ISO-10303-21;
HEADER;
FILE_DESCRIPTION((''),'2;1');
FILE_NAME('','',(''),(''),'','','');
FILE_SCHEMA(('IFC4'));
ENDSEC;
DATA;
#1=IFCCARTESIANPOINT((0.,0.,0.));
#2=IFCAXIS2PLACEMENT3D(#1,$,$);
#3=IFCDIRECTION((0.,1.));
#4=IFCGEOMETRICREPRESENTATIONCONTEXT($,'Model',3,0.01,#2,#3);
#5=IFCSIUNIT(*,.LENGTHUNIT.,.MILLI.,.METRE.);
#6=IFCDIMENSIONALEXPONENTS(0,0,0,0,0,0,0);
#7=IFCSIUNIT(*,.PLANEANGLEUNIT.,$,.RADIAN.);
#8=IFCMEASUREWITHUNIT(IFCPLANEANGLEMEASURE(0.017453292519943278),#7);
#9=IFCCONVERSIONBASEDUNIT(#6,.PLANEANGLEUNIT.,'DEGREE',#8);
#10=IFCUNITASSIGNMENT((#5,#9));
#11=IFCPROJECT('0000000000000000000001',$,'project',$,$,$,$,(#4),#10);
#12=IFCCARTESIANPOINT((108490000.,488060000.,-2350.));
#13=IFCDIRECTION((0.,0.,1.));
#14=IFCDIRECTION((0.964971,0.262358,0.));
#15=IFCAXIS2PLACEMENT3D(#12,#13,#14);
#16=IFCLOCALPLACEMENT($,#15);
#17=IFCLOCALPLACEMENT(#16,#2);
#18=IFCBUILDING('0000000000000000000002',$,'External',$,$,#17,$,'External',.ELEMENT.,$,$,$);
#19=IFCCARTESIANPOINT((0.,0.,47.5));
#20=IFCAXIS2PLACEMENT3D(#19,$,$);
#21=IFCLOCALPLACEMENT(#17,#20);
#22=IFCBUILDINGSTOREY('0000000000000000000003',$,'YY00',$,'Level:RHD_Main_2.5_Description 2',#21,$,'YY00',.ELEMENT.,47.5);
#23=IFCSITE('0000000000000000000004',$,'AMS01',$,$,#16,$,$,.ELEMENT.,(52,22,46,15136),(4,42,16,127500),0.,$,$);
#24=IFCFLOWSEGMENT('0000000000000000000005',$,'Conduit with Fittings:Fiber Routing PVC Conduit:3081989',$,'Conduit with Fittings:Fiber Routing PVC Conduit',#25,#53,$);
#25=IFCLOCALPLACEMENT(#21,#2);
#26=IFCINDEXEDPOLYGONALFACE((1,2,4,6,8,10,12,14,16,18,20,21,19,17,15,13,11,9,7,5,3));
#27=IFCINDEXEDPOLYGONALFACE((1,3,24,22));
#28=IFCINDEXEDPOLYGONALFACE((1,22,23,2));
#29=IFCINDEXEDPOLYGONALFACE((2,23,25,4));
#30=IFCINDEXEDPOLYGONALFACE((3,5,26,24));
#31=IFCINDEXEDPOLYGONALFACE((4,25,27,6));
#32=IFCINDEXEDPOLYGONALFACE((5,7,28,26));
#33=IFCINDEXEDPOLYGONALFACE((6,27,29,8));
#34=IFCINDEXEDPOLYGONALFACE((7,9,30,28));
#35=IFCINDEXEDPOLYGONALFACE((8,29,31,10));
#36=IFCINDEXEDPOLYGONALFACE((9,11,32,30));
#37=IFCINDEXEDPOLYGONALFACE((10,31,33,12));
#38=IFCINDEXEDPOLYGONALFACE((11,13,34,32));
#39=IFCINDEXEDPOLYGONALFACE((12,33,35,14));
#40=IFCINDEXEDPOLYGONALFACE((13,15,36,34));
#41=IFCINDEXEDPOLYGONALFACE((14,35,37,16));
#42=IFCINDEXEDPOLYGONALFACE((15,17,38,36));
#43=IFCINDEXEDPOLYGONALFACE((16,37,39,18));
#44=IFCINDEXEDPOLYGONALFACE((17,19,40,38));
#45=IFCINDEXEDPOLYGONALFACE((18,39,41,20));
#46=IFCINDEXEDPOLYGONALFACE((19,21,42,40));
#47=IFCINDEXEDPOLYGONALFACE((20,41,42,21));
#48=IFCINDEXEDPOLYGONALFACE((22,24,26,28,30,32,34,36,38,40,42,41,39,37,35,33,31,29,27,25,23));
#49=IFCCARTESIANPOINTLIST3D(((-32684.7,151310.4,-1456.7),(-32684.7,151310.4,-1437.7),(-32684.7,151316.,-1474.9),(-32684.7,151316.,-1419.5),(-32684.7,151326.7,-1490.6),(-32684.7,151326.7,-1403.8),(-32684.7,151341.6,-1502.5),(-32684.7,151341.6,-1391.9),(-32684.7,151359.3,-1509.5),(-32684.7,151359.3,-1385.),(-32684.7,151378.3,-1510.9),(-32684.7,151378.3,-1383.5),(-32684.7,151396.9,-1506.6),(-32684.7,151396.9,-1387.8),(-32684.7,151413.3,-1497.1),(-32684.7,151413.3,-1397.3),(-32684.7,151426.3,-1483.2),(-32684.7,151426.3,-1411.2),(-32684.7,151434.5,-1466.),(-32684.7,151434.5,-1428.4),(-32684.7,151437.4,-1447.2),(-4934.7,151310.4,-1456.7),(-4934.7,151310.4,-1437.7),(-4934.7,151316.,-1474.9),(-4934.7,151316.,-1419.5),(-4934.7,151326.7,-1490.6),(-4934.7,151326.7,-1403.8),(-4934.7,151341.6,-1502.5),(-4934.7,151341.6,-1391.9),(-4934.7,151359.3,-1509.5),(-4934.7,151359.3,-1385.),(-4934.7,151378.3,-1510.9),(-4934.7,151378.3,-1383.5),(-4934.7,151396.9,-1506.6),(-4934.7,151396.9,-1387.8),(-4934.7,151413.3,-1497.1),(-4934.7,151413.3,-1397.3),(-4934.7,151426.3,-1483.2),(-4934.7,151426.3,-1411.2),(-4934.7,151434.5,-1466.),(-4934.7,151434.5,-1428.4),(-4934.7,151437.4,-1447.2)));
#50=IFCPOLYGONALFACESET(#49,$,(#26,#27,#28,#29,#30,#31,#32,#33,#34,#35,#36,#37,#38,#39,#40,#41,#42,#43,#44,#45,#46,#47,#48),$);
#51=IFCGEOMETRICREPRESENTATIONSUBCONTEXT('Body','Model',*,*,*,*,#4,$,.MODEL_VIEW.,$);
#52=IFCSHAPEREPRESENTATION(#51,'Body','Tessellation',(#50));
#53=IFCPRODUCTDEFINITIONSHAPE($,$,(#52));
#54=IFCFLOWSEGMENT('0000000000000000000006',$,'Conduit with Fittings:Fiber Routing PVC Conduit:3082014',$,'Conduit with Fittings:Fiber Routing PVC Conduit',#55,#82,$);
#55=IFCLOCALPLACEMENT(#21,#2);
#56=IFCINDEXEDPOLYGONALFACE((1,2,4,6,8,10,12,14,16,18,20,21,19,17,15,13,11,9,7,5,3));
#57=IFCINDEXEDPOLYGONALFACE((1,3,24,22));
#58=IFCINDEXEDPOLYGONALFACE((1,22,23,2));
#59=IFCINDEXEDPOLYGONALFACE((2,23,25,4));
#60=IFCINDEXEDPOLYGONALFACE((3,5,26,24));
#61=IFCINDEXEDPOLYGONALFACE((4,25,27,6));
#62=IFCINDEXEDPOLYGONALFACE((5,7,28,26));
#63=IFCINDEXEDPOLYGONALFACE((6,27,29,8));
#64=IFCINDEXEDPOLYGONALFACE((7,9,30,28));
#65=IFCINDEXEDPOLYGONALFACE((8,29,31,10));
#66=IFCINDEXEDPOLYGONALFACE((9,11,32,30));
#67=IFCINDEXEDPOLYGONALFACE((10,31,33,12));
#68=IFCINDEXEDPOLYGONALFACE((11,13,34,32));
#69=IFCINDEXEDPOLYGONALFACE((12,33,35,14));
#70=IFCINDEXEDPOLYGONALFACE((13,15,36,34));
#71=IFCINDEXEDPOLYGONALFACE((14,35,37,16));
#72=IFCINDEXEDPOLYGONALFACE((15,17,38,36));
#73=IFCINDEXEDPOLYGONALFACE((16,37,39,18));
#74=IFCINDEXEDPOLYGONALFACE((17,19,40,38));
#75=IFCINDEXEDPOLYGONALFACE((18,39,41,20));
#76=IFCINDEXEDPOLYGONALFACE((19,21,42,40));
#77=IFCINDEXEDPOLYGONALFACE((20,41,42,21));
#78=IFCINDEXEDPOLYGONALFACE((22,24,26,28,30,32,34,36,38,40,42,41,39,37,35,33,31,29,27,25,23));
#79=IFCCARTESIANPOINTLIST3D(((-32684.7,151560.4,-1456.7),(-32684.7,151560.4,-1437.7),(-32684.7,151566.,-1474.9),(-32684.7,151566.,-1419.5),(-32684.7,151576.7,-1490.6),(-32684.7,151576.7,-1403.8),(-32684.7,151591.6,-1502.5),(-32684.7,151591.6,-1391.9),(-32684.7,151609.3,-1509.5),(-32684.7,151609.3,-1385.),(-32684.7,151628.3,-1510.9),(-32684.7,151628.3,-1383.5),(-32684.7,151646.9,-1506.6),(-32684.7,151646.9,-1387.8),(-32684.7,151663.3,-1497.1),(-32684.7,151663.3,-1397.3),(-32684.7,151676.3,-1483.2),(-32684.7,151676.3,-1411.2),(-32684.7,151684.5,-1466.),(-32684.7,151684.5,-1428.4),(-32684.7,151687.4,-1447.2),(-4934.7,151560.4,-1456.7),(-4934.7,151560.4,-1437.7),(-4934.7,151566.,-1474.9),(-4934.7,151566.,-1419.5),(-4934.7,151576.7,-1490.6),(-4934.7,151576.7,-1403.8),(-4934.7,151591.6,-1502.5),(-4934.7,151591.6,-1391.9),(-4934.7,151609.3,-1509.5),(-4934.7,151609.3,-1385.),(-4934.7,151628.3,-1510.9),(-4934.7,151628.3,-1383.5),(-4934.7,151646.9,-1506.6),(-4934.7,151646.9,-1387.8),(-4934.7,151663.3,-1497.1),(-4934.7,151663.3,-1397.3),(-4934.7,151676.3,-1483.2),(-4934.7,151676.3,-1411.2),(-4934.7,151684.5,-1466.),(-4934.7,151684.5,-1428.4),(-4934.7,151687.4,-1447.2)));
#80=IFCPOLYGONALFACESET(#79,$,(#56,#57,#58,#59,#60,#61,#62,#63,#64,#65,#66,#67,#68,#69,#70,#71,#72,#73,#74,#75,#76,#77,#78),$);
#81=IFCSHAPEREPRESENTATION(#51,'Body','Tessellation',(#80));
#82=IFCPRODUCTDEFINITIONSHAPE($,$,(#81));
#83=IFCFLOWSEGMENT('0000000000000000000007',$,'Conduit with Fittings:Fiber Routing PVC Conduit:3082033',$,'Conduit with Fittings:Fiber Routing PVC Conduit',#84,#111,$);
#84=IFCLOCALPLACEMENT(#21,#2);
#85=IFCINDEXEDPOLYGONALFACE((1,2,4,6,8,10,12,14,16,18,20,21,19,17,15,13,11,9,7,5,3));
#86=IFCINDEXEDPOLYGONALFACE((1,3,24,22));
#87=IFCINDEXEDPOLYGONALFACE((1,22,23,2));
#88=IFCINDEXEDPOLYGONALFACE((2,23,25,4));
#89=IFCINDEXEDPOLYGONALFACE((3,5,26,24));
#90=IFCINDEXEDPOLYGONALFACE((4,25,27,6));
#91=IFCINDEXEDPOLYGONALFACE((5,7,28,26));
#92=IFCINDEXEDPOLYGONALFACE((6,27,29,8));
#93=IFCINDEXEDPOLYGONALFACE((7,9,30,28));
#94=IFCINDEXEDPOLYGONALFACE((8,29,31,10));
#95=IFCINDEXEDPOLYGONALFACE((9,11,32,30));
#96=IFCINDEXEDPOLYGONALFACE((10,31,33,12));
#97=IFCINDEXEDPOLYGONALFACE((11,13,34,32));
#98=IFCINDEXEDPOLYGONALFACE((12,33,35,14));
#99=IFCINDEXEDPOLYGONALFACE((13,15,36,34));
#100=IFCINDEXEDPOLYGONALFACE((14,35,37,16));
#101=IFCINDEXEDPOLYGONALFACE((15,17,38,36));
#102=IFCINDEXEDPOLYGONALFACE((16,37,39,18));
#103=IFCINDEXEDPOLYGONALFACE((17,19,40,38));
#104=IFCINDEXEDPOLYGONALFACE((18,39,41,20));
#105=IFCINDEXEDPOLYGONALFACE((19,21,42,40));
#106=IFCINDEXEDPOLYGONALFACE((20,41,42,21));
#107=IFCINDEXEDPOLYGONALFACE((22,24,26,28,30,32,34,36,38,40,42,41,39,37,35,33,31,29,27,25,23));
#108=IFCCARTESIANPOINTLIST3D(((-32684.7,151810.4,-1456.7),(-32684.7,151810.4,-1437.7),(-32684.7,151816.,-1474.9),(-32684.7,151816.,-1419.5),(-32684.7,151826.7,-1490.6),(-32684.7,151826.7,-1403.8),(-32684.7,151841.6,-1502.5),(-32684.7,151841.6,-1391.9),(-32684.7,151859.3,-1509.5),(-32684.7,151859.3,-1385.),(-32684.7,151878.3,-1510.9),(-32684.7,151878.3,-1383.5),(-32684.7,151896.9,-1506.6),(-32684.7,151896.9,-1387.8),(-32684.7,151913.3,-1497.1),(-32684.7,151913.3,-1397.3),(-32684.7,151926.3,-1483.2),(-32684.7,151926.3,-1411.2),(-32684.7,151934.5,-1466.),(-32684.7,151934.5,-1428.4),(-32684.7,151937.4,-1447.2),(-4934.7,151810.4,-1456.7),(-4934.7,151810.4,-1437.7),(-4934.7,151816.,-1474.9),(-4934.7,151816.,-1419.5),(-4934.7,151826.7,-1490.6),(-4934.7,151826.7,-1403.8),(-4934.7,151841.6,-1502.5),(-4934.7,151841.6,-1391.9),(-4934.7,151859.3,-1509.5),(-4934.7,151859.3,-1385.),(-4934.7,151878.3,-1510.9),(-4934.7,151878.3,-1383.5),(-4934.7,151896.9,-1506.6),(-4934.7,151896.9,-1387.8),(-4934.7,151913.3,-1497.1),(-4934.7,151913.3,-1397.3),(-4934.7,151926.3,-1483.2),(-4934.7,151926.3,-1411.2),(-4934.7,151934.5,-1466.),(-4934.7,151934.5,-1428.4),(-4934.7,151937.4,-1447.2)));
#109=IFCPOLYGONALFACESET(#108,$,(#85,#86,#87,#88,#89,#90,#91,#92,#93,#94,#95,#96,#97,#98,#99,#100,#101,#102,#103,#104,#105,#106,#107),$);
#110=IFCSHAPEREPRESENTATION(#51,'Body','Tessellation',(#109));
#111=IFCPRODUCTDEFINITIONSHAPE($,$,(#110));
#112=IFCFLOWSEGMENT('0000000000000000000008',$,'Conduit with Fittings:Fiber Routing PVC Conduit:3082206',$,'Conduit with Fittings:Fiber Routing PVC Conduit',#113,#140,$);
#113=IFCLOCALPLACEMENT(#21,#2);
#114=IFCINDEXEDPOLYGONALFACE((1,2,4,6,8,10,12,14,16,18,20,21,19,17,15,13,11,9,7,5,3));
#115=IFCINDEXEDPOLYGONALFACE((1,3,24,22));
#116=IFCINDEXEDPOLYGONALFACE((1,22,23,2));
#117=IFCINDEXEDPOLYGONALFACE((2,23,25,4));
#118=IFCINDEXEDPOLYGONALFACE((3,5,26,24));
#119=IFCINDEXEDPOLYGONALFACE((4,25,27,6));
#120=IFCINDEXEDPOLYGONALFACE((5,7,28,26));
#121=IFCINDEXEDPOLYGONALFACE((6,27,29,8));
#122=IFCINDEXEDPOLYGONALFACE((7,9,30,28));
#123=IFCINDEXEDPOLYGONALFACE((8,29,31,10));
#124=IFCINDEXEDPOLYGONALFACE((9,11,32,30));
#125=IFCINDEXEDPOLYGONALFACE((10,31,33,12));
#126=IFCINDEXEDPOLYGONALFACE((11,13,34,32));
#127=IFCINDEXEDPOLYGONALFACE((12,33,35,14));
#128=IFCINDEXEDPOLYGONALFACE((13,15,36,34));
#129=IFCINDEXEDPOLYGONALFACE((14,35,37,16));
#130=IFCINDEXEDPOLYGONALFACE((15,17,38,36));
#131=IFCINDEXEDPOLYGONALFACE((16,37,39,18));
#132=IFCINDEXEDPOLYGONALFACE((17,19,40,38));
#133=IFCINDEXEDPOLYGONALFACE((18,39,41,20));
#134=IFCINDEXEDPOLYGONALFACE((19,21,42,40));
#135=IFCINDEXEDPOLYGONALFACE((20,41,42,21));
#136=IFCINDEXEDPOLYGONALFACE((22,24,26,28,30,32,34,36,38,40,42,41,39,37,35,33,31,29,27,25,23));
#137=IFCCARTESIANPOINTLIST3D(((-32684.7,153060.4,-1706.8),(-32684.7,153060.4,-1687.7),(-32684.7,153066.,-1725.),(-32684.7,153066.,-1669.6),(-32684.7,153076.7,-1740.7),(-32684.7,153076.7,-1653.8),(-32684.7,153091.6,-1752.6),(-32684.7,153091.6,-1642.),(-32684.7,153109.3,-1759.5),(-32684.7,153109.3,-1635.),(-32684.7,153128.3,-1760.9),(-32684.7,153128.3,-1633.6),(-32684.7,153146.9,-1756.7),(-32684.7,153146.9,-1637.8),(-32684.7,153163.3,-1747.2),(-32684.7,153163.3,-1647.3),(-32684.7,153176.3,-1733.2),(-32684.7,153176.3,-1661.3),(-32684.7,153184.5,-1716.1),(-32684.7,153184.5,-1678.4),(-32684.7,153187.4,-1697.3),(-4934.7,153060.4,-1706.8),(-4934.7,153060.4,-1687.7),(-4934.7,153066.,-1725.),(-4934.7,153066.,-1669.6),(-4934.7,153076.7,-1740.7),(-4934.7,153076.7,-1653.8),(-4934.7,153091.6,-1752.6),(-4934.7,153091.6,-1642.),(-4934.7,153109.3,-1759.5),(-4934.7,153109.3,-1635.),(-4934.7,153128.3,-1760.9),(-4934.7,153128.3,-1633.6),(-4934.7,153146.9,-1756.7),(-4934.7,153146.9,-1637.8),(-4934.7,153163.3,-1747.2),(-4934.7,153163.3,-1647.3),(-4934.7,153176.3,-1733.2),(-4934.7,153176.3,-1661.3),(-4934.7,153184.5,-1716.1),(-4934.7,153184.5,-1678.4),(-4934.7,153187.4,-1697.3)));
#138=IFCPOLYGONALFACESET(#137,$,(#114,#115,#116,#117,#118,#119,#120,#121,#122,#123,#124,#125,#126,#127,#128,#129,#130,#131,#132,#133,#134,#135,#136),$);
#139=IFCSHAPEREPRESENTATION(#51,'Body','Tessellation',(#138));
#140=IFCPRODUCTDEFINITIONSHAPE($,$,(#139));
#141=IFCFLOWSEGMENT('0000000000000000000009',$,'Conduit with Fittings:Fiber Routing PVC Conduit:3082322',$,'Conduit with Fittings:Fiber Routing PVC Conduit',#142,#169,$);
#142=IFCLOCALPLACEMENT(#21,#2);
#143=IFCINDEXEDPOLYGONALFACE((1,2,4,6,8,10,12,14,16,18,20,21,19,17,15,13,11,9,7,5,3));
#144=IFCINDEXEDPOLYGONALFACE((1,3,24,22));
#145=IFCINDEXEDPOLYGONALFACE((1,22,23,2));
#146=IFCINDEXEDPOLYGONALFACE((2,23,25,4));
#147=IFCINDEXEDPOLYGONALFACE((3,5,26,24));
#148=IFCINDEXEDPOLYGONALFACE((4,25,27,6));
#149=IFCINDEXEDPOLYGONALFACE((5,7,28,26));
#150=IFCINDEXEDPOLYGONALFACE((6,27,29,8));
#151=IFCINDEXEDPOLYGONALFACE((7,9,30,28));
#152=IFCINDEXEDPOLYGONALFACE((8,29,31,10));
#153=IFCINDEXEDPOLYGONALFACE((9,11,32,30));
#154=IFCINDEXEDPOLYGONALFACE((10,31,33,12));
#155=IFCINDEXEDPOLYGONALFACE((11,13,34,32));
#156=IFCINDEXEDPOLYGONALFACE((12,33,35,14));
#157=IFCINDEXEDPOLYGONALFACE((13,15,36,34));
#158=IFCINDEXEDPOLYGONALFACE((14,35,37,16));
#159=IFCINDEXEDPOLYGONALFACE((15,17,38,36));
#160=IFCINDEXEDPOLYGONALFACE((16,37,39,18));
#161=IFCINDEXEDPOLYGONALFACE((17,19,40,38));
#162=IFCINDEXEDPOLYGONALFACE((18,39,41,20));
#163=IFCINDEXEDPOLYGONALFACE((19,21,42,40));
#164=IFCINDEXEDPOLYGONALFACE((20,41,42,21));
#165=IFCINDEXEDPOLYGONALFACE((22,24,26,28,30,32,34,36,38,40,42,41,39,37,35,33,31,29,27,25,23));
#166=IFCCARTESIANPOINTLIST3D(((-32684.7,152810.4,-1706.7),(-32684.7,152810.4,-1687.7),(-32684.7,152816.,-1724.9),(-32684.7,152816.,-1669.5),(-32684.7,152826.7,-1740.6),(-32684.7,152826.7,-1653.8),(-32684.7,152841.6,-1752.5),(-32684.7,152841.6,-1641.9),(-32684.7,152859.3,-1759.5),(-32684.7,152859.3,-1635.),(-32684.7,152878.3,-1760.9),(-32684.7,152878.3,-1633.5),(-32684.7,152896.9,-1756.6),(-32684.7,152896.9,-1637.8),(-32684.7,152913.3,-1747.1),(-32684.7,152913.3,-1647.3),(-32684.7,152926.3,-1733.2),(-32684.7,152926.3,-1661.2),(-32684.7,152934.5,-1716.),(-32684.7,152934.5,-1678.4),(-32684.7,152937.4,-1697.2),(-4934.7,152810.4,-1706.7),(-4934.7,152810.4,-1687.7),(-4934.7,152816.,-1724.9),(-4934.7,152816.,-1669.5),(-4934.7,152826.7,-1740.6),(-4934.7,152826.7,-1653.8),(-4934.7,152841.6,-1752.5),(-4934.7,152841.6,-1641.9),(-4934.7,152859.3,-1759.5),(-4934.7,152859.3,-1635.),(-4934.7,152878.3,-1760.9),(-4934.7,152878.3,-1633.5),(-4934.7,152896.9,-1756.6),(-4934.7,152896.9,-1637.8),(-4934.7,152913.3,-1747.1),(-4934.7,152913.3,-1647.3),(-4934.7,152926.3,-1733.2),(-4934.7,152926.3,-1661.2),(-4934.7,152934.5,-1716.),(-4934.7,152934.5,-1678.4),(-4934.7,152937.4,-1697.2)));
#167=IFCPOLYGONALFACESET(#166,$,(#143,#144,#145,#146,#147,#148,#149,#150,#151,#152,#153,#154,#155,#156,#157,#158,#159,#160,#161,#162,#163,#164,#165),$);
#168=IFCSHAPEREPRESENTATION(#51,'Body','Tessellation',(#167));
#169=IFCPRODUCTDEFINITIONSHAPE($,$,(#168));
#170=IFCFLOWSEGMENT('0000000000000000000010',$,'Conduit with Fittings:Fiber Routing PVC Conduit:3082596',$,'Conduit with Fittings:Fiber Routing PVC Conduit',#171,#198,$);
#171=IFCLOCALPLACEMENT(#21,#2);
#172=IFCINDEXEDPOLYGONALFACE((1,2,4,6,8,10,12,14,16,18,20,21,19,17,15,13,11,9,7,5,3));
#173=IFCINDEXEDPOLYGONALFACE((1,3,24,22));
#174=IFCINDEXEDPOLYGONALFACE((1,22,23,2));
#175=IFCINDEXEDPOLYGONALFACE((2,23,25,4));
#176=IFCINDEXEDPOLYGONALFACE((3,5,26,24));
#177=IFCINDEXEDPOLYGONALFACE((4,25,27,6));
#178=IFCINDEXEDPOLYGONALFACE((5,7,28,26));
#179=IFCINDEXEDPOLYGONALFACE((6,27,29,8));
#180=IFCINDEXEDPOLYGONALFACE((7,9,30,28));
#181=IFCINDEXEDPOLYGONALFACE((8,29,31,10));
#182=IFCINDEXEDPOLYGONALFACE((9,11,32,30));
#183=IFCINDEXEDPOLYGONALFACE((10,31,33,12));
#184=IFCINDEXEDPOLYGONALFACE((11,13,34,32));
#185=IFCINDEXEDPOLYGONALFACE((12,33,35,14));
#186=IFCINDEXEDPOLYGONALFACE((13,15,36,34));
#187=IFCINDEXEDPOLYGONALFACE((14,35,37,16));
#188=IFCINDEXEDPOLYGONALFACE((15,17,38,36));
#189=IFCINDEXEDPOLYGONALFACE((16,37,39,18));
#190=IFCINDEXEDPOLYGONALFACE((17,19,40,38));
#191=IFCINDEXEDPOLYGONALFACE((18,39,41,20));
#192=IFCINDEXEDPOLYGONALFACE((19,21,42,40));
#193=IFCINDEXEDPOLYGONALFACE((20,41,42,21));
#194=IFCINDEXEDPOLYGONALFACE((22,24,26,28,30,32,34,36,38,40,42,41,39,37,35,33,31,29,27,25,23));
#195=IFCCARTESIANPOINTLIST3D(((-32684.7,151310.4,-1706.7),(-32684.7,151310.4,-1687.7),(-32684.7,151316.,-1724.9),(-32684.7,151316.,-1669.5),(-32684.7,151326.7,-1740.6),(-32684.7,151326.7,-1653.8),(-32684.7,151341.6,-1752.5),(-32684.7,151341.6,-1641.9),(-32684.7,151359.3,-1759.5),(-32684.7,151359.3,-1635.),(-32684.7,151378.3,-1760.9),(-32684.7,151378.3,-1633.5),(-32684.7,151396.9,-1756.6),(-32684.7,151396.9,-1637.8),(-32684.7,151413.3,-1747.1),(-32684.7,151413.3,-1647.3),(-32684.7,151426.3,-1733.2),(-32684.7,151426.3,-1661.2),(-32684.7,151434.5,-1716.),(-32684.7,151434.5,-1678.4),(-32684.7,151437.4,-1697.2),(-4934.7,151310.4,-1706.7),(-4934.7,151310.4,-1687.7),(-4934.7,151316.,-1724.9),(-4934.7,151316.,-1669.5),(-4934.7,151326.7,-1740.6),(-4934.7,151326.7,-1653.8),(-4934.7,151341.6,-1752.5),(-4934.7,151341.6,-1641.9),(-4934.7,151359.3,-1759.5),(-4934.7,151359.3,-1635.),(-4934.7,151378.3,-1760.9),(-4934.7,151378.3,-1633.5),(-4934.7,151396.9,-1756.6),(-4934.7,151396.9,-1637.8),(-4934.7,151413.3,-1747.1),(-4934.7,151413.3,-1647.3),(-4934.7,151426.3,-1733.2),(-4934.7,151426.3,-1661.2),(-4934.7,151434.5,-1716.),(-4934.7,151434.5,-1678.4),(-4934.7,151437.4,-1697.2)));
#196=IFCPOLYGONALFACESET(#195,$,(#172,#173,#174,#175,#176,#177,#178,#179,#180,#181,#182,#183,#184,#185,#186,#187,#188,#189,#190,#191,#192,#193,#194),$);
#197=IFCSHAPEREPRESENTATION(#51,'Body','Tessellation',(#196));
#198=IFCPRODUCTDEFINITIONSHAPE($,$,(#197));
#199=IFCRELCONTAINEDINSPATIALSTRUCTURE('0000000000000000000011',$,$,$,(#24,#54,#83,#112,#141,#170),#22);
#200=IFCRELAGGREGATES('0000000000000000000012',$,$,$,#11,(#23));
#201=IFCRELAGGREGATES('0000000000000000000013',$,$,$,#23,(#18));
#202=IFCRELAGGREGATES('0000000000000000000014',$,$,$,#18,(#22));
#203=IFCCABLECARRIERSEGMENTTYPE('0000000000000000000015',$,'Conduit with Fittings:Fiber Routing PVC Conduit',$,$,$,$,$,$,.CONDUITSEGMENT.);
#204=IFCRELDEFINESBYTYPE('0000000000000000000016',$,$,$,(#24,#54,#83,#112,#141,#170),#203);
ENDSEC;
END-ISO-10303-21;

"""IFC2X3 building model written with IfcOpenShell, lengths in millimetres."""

from ifc_helpers import new_model, entity, si_unit, converted_unit, direction, frame, frame_2d, origin, place, context, subcontext, project, spatial, circle, extrude, type_object, element, save


model = new_model("IFC2X3")

# Units and contexts
model_context = context("Model", 3, precision=0.01, world=origin(), true_north=direction((0.0, 1.0)))
body_context = subcontext(model_context, "Body", "Model", "MODEL_VIEW")
ifc_project = project(units=[si_unit("LENGTHUNIT", "METRE", prefix="MILLI"), converted_unit("PLANEANGLEUNIT", "DEGREE", entity("IfcPlaneAngleMeasure", 0.017453292519943278), si_unit("PLANEANGLEUNIT", "RADIAN"), dimensions=[0, 0, 0, 0, 0, 0, 0])], contexts=[model_context])

# Site, building, storey
site_placement = place(None, frame((108490000.0, 488060000.0, -2350.0), z_axis=(0.0, 0.0, 1.0), x_axis=(0.964971, 0.262358, 0.0)))
site = spatial("IfcSite", under=ifc_project, at=site_placement, Name="AMS01", CompositionType="ELEMENT", RefLatitude=(52, 22, 46, 15136), RefLongitude=(4, 42, 16, 127500), RefElevation=0.0)
building_placement = place(site_placement, origin())
building = spatial("IfcBuilding", under=site, at=building_placement, Name="External", LongName="External", CompositionType="ELEMENT")
storey_placement = place(building_placement, frame((0.0, 0.0, 47.5)))
storey = spatial("IfcBuildingStorey", under=building, at=storey_placement, Name="YY00", ObjectType="Level:RHD_Main_2.5_Description 2", LongName="YY00", CompositionType="ELEMENT", Elevation=47.5)

# Flow segments
cable_carrier_segment_type = type_object("IfcCableCarrierSegmentType", Name="Conduit with Fittings:Fiber Routing PVC Conduit", PredefinedType="CONDUITSEGMENT")
flow_segment_1_placement = place(storey_placement, origin())
element("IfcFlowSegment", 1, at=flow_segment_1_placement, inside=storey, type_object=cable_carrier_segment_type, Name="Conduit with Fittings:Fiber Routing PVC Conduit:3081989", ObjectType="Conduit with Fittings:Fiber Routing PVC Conduit", context=body_context, shape_type="SweptSolid", body=[
    extrude(circle(Radius=63.9, at=frame_2d((0.0, 0.0), x_axis=(1.0, 0.0))), frame((-32684.7, 151373.5, -1447.2), z_axis=(1.0, 0.0, 0.0), x_axis=(0.0, 1.0, 0.0)), (0.0, 0.0, 1.0), 27750.0),
])
flow_segment_2_placement = place(storey_placement, origin())
element("IfcFlowSegment", 2, at=flow_segment_2_placement, inside=storey, type_object=cable_carrier_segment_type, Name="Conduit with Fittings:Fiber Routing PVC Conduit:3082014", ObjectType="Conduit with Fittings:Fiber Routing PVC Conduit", context=body_context, shape_type="SweptSolid", body=[
    extrude(circle(Radius=63.9, at=frame_2d((0.0, 0.0), x_axis=(1.0, 0.0))), frame((-32684.7, 151623.5, -1447.2), z_axis=(1.0, 0.0, 0.0), x_axis=(0.0, 1.0, 0.0)), (0.0, 0.0, 1.0), 27750.0),
])
flow_segment_3_placement = place(storey_placement, origin())
element("IfcFlowSegment", 3, at=flow_segment_3_placement, inside=storey, type_object=cable_carrier_segment_type, Name="Conduit with Fittings:Fiber Routing PVC Conduit:3082033", ObjectType="Conduit with Fittings:Fiber Routing PVC Conduit", context=body_context, shape_type="SweptSolid", body=[
    extrude(circle(Radius=63.9, at=frame_2d((0.0, 0.0), x_axis=(1.0, 0.0))), frame((-32684.7, 151873.5, -1447.2), z_axis=(1.0, 0.0, 0.0), x_axis=(0.0, 1.0, 0.0)), (0.0, 0.0, 1.0), 27750.0),
])
flow_segment_4_placement = place(storey_placement, origin())
element("IfcFlowSegment", 4, at=flow_segment_4_placement, inside=storey, type_object=cable_carrier_segment_type, Name="Conduit with Fittings:Fiber Routing PVC Conduit:3082206", ObjectType="Conduit with Fittings:Fiber Routing PVC Conduit", context=body_context, shape_type="SweptSolid", body=[
    extrude(circle(Radius=63.9, at=frame_2d((0.0, 0.0), x_axis=(1.0, 0.0))), frame((-32684.7, 153123.5, -1697.3), z_axis=(1.0, 0.0, 0.0), x_axis=(0.0, 1.0, 0.0)), (0.0, 0.0, 1.0), 27750.0),
])
flow_segment_5_placement = place(storey_placement, origin())
element("IfcFlowSegment", 5, at=flow_segment_5_placement, inside=storey, type_object=cable_carrier_segment_type, Name="Conduit with Fittings:Fiber Routing PVC Conduit:3082322", ObjectType="Conduit with Fittings:Fiber Routing PVC Conduit", context=body_context, shape_type="SweptSolid", body=[
    extrude(circle(Radius=63.9, at=frame_2d((0.0, 0.0), x_axis=(1.0, 0.0))), frame((-32684.7, 152873.5, -1697.2), z_axis=(1.0, 0.0, 0.0), x_axis=(0.0, 1.0, 0.0)), (0.0, 0.0, 1.0), 27750.0),
])
flow_segment_6_placement = place(storey_placement, origin())
element("IfcFlowSegment", 6, at=flow_segment_6_placement, inside=storey, type_object=cable_carrier_segment_type, Name="Conduit with Fittings:Fiber Routing PVC Conduit:3082596", ObjectType="Conduit with Fittings:Fiber Routing PVC Conduit", context=body_context, shape_type="SweptSolid", body=[
    extrude(circle(Radius=63.9, at=frame_2d((0.0, 0.0), x_axis=(1.0, 0.0))), frame((-32684.7, 151373.5, -1697.2), z_axis=(1.0, 0.0, 0.0), x_axis=(0.0, 1.0, 0.0)), (0.0, 0.0, 1.0), 27750.0),
])

save(model, "model.ifc")
